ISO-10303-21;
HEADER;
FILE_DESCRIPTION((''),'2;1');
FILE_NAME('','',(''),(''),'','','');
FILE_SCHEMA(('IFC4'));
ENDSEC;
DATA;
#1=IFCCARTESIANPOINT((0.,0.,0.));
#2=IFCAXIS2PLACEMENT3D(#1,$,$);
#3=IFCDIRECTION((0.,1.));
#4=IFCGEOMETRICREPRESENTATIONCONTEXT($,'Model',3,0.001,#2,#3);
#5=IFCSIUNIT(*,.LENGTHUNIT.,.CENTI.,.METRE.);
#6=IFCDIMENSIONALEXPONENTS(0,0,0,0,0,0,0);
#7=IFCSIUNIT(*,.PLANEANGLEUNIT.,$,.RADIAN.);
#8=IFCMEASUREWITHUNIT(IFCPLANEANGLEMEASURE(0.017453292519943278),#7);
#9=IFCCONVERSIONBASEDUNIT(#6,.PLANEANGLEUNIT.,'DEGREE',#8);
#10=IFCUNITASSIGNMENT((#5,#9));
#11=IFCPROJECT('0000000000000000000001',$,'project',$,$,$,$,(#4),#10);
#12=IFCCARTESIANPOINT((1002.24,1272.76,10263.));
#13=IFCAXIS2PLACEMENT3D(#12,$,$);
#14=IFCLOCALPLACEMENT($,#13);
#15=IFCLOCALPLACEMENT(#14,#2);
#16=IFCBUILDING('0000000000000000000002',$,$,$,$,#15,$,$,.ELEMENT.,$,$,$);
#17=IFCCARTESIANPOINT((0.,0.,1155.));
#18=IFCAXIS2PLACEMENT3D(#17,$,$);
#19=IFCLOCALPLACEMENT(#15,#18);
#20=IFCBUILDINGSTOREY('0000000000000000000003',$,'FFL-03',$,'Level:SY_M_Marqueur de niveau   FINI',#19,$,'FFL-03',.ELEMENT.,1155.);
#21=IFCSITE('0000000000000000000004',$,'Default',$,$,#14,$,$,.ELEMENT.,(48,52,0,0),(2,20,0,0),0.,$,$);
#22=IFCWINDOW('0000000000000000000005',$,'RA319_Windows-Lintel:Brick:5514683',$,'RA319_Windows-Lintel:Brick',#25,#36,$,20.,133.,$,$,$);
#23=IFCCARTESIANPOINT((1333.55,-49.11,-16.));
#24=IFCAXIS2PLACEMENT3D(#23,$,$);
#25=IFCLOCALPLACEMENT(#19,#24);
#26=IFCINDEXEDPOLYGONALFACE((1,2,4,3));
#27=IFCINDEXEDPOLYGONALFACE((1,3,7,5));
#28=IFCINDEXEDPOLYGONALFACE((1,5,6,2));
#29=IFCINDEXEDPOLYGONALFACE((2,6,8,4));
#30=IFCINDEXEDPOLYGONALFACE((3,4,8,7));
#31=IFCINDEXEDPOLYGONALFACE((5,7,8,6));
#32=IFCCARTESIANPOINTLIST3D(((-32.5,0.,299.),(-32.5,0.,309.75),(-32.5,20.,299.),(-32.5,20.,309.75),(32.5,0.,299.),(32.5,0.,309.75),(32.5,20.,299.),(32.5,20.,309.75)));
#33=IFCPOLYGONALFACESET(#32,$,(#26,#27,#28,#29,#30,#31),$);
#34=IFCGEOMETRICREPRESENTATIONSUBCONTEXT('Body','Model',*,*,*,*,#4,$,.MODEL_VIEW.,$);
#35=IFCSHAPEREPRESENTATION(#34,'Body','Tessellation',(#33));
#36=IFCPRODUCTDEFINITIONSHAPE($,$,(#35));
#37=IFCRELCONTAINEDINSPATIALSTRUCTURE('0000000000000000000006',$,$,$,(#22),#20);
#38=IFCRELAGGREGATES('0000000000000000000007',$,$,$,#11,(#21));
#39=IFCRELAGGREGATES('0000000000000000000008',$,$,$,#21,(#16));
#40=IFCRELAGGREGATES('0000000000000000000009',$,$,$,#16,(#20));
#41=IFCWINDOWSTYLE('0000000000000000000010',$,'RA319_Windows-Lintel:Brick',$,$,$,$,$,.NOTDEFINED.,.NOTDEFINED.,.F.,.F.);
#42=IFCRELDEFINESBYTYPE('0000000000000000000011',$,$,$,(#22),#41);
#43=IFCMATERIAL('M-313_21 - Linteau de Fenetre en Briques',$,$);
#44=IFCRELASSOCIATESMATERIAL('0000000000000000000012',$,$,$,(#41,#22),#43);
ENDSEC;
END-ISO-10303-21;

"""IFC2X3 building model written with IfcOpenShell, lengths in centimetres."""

from ifc_helpers import new_model, entity, si_unit, converted_unit, direction, frame, origin, origin_2d_with_axis, place, context, subcontext, project, spatial, rectangle, extrude, source, transform, mapped, material, type_object, type_shapes, element, save


model = new_model("IFC2X3")

# Units and contexts
model_context = context("Model", 3, precision=0.001, world=origin(), true_north=direction((0.0, 1.0)))
body_context = subcontext(model_context, "Body", "Model", "MODEL_VIEW")
ifc_project = project(units=[si_unit("LENGTHUNIT", "METRE", prefix="CENTI"), converted_unit("PLANEANGLEUNIT", "DEGREE", entity("IfcPlaneAngleMeasure", 0.017453292519943278), si_unit("PLANEANGLEUNIT", "RADIAN"), dimensions=[0, 0, 0, 0, 0, 0, 0])], contexts=[model_context])

# Site, building, storey
site_placement = place(None, frame((1002.24, 1272.76, 10263.0)))
site = spatial("IfcSite", under=ifc_project, at=site_placement, Name="Default", CompositionType="ELEMENT", RefLatitude=(48, 52, 0, 0), RefLongitude=(2, 20, 0, 0), RefElevation=0.0)
building_placement = place(site_placement, origin())
building = spatial("IfcBuilding", under=site, at=building_placement, CompositionType="ELEMENT")
storey_placement = place(building_placement, frame((0.0, 0.0, 1155.0)))
storey = spatial("IfcBuildingStorey", under=building, at=storey_placement, Name="FFL-03", ObjectType="Level:SY_M_Marqueur de niveau   FINI", LongName="FFL-03", CompositionType="ELEMENT", Elevation=1155.0)

# Window
ifc_material_1 = material(Name="M-313_21 - Linteau de Fenetre en Briques")
window_style_1 = type_object("IfcWindowStyle", Name="RA319_Windows-Lintel:Brick", ConstructionType="NOTDEFINED", OperationType="NOTDEFINED", ParameterTakesPrecedence=False, Sizeable=False, material=ifc_material_1)
shared_shape_1 = source(origin(), body_context, "Body", "SweptSolid", [
    extrude(rectangle(XDim=20.0, YDim=65.0, at=origin_2d_with_axis()), frame((0.0, 10.0, 299.0), z_axis=(0.0, 0.0, 1.0), x_axis=(0.0, -1.0, 0.0)), (0.0, 0.0, 1.0), 10.75),
])
type_shapes(window_style_1, [shared_shape_1])
window_1_placement = place(storey_placement, frame((1333.55, -49.11, -16.0)))
element("IfcWindow", 1, at=window_1_placement, inside=storey, type_object=window_style_1, material=ifc_material_1, Name="RA319_Windows-Lintel:Brick:5514683", ObjectType="RA319_Windows-Lintel:Brick", OverallHeight=20.0, OverallWidth=133.0, context=body_context, shape_type="MappedRepresentation", body=[
    mapped(shared_shape_1, transform((0.0, 0.0, 0.0), scale=1.0)),
])

save(model, "model.ifc")
